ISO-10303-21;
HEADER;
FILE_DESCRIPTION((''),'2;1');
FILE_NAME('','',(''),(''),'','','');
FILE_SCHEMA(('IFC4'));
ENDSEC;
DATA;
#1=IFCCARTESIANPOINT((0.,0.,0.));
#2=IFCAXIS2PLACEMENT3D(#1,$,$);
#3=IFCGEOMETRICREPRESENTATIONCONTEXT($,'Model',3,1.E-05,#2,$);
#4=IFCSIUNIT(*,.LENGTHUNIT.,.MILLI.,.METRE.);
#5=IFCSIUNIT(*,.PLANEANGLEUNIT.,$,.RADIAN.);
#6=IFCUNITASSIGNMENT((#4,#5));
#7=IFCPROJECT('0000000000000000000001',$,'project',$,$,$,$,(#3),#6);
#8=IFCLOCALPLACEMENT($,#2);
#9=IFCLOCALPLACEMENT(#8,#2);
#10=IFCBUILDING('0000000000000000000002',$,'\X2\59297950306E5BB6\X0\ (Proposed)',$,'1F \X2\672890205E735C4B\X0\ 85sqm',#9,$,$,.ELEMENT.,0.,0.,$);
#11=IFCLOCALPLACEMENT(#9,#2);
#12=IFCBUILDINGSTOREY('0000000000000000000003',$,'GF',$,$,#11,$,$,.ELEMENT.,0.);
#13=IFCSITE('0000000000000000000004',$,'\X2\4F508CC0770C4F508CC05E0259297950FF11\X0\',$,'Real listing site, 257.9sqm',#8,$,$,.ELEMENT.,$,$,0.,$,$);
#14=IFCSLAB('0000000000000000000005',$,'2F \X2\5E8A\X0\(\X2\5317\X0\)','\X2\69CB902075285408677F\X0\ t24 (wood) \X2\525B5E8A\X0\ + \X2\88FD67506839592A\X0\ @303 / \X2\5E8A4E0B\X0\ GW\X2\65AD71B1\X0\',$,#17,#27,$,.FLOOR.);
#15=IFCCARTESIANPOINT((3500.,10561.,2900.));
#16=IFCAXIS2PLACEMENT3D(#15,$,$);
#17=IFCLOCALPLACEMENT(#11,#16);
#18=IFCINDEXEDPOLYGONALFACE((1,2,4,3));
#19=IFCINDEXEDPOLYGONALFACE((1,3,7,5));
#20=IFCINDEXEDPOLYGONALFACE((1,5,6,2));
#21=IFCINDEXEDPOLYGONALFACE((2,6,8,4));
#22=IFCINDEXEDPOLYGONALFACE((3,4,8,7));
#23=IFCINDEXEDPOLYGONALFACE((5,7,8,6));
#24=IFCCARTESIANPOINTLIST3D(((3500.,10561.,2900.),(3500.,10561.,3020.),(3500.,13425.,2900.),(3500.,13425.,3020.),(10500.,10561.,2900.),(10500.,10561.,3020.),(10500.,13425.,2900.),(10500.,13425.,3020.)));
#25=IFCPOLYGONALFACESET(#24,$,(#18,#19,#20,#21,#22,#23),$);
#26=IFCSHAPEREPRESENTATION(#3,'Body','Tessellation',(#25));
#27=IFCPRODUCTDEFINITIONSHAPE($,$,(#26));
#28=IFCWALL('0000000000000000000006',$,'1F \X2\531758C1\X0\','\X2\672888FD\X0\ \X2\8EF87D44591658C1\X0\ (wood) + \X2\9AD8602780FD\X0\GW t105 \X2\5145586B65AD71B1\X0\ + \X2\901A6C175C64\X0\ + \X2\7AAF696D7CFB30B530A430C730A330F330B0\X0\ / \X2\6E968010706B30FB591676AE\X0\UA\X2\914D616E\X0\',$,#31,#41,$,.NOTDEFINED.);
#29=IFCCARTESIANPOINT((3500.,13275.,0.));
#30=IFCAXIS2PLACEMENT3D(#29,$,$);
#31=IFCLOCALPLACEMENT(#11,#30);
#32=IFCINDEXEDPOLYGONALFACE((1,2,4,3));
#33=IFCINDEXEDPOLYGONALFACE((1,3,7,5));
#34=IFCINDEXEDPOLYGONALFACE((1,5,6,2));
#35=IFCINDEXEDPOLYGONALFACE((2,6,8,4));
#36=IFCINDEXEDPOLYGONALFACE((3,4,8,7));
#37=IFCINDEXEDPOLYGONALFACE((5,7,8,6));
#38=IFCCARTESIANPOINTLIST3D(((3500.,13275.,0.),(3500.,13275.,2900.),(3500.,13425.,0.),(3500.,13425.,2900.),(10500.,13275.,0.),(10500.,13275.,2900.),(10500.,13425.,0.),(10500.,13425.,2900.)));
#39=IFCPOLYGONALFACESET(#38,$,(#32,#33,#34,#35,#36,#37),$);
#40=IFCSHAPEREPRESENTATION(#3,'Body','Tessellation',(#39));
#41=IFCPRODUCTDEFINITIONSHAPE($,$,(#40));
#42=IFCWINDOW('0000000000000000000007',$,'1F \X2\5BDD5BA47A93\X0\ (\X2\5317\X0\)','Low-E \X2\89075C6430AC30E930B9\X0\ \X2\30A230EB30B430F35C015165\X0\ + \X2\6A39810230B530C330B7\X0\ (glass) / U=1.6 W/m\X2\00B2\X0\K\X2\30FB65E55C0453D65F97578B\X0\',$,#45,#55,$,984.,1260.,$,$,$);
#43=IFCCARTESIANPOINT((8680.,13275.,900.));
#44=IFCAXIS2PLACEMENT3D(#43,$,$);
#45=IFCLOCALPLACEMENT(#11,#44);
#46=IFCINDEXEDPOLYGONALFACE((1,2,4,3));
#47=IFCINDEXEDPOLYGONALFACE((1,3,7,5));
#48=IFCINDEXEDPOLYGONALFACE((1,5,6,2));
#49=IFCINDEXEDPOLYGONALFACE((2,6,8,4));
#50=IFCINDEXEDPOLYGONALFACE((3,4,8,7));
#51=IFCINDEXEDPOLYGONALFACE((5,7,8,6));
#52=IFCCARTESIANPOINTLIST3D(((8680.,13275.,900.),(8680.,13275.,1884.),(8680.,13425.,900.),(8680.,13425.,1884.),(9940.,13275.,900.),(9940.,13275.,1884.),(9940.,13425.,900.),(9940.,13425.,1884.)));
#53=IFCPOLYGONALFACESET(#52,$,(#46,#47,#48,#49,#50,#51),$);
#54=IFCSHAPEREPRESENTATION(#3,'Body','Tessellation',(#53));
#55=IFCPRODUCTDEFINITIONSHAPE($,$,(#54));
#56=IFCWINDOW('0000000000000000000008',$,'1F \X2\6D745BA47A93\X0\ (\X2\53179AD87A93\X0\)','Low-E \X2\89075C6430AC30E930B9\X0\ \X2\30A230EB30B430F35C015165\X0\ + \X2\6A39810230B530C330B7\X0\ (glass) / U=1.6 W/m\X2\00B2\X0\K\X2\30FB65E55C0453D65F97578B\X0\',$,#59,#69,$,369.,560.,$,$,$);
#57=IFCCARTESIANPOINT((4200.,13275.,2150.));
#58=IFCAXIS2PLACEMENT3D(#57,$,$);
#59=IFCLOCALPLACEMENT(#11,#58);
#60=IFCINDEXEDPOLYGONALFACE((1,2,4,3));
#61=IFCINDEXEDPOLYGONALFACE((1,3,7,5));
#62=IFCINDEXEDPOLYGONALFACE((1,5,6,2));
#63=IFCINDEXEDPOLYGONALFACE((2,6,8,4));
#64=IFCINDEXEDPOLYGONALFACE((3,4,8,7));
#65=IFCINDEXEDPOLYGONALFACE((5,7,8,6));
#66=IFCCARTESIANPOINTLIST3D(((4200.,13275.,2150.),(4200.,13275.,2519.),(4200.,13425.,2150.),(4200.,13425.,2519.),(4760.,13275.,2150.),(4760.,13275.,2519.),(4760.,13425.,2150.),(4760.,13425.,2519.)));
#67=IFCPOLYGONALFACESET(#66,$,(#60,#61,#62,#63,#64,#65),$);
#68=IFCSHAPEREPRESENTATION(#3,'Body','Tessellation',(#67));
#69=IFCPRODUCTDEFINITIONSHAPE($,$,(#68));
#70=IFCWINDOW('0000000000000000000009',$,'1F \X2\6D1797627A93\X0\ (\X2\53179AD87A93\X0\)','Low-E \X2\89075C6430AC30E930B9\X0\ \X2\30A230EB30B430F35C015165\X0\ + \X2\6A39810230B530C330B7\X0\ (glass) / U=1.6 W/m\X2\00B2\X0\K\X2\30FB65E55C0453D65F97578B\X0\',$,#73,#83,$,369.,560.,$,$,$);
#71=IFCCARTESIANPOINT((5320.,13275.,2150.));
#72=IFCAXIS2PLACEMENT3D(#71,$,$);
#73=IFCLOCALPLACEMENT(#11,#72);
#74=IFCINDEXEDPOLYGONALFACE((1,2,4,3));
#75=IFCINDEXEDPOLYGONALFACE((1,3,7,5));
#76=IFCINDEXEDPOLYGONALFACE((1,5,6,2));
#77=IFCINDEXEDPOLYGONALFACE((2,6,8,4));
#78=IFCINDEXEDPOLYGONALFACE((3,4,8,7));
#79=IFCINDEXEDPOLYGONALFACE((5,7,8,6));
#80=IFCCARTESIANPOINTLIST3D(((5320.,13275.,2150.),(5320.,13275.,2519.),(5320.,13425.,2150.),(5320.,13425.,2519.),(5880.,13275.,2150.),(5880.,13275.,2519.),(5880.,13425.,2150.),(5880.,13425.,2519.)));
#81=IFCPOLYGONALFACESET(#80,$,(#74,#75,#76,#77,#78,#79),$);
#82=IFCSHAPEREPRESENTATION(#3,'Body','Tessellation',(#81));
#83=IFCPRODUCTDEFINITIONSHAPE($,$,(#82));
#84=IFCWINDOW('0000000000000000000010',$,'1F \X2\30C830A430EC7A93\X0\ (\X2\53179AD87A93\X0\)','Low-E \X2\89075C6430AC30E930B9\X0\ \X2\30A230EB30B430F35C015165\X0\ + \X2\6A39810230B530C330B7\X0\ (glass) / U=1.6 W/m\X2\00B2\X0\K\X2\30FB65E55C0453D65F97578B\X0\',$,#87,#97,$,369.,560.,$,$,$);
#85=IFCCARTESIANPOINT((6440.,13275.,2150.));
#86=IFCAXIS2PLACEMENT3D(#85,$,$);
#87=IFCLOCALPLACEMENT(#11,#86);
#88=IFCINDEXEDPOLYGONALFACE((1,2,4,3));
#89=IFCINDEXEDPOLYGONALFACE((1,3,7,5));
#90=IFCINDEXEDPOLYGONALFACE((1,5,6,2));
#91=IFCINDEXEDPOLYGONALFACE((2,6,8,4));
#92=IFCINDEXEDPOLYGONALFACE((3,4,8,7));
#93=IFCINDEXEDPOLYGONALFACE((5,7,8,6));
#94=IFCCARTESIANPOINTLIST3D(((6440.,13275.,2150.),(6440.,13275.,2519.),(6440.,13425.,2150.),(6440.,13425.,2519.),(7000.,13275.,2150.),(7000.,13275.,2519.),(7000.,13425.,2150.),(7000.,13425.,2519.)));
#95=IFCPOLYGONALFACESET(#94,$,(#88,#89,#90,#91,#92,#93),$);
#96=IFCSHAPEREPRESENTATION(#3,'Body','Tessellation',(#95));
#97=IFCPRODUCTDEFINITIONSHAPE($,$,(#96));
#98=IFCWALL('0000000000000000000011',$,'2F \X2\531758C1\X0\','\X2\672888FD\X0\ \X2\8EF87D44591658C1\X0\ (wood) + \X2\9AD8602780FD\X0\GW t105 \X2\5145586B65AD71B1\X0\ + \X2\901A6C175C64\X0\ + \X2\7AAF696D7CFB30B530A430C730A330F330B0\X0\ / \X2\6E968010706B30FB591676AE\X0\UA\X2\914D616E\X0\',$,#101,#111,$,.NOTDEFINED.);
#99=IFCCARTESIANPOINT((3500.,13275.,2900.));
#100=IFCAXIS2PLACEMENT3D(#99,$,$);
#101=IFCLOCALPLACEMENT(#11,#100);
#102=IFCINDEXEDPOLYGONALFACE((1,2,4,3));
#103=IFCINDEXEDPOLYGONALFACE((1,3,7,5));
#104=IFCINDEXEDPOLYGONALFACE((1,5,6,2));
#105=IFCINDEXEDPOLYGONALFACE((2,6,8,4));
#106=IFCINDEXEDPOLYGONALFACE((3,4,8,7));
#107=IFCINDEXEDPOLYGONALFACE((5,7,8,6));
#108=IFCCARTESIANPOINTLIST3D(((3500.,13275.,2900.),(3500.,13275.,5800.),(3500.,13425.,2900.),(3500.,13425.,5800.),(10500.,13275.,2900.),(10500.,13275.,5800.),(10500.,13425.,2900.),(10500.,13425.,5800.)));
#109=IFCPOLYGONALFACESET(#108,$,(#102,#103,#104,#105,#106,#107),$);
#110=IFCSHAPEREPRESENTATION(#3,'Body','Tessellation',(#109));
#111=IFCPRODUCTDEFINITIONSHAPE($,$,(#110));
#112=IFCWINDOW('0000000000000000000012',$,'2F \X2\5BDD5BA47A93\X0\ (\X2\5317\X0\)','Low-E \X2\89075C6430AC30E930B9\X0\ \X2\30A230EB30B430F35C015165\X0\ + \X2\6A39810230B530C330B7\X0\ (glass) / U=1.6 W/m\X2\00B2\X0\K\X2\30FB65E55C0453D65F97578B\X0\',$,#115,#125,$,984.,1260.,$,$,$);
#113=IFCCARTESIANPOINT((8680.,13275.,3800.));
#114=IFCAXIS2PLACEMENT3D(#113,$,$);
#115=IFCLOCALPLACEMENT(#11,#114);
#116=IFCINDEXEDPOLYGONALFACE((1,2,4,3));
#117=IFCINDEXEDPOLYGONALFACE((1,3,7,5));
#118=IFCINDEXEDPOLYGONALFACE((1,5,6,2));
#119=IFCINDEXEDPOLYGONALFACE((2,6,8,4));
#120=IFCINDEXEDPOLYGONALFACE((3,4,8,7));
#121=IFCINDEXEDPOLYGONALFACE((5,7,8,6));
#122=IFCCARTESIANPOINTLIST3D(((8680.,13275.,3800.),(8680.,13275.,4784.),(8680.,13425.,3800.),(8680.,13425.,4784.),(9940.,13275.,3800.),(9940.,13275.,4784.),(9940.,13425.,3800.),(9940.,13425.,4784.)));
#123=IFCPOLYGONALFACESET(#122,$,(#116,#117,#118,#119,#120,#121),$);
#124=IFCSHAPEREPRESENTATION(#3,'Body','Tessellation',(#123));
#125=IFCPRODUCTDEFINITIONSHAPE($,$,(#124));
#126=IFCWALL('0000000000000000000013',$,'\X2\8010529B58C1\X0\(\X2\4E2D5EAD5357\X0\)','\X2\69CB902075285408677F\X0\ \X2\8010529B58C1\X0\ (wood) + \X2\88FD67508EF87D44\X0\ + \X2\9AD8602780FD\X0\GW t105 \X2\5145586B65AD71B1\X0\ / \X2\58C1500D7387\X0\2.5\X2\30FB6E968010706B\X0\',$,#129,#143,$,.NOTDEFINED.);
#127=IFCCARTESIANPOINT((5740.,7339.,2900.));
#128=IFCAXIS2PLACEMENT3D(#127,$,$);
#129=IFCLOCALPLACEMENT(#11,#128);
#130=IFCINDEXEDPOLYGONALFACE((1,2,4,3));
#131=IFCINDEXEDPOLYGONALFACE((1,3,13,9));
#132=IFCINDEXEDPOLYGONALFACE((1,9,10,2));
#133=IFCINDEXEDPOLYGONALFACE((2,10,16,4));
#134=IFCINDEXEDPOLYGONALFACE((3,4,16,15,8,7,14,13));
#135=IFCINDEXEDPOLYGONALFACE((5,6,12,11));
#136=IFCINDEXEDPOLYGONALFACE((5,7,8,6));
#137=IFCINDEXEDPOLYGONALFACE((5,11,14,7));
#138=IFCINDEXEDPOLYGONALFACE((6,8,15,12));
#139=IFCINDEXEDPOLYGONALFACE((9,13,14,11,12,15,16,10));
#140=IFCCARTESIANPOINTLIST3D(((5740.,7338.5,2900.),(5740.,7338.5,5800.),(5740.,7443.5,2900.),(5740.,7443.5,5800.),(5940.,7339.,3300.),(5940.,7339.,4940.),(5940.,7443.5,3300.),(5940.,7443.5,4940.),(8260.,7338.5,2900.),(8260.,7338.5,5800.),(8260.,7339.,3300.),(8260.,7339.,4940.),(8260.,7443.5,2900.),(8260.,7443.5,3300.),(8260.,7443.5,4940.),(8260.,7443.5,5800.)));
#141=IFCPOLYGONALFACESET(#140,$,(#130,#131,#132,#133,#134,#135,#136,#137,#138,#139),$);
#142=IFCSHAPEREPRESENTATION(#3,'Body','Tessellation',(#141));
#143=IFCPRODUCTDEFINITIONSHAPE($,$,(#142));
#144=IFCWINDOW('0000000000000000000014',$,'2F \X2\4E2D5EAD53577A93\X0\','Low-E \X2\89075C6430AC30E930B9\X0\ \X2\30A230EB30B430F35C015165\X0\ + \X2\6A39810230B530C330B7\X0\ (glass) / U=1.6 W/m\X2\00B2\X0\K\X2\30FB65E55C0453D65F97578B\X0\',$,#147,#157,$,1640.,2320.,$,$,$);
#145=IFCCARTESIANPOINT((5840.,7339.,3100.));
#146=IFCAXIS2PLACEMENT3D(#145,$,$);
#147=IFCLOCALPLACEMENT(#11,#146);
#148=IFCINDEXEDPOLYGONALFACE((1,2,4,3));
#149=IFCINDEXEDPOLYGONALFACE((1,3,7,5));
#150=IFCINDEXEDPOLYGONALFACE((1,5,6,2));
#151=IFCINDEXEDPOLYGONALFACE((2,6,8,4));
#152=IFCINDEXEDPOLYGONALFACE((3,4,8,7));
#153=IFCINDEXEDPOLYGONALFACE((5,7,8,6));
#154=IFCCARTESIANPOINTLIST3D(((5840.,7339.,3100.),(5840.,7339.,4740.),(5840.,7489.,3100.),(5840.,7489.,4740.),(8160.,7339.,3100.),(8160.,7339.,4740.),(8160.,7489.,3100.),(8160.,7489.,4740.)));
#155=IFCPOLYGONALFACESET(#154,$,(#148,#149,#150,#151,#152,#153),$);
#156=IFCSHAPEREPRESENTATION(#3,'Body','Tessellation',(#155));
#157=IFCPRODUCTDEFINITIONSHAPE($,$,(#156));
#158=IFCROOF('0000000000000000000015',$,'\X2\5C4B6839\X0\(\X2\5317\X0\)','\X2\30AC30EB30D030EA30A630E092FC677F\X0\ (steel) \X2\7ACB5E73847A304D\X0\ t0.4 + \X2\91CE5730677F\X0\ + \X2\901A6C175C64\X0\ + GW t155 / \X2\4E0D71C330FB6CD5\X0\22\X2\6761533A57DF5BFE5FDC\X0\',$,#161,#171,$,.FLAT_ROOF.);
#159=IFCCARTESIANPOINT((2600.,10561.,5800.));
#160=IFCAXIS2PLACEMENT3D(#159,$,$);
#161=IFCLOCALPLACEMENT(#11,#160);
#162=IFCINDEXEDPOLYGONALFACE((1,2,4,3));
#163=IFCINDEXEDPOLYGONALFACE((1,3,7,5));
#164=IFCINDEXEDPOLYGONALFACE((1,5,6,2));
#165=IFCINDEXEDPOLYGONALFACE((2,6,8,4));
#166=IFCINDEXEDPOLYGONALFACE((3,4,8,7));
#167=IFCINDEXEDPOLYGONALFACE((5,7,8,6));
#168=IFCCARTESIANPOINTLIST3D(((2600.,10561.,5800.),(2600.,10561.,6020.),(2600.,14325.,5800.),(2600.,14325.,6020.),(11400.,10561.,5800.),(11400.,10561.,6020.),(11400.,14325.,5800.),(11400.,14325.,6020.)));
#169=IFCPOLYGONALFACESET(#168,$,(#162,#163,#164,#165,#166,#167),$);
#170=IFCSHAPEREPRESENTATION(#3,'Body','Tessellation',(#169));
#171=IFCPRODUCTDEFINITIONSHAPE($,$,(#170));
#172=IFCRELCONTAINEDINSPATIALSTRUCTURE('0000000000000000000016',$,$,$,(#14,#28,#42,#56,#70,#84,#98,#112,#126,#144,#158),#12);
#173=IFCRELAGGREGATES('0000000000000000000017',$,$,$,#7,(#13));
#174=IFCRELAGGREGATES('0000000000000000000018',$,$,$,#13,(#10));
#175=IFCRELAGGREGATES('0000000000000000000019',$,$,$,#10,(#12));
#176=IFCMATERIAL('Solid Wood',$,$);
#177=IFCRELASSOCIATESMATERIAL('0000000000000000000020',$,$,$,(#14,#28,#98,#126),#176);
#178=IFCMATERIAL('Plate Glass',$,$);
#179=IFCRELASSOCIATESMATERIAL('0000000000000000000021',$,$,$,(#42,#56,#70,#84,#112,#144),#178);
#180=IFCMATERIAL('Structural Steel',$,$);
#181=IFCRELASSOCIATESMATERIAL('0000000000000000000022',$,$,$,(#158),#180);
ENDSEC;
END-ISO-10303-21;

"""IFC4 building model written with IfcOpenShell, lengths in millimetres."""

from ifc_helpers import new_model, si_unit, frame, frame_2d, origin, place, context, project, spatial, rectangle, extrude, material, element, fill, save


model = new_model("IFC4")

# Units and contexts
model_context = context("Model", 3, precision=1e-05, world=origin())
ifc_project = project(units=[si_unit("LENGTHUNIT", "METRE", prefix="MILLI"), si_unit("PLANEANGLEUNIT", "RADIAN")], contexts=[model_context])

# Site, building, storey
site_placement = place(None, origin())
site = spatial("IfcSite", under=ifc_project, at=site_placement, Name="佐賀県佐賀市天祐１", ObjectType="Real listing site, 257.9sqm", CompositionType="ELEMENT", RefElevation=0.0)
building_placement = place(site_placement, origin())
building = spatial("IfcBuilding", under=site, at=building_placement, Name="天祐の家 (Proposed)", ObjectType="1F 木造平屋 85sqm", CompositionType="ELEMENT", ElevationOfRefHeight=0.0, ElevationOfTerrain=0.0)
storey_placement = place(building_placement, origin())
storey = spatial("IfcBuildingStorey", under=building, at=storey_placement, Name="GF", CompositionType="ELEMENT", Elevation=0.0)

# Slab
ifc_material_1 = material(Name="Solid Wood")
slab_1_placement = place(storey_placement, frame((3500.0, 10561.0, 2900.0)))
element("IfcSlab", 1, at=slab_1_placement, inside=storey, material=ifc_material_1, Name="2F 床(北)", Description="構造用合板 t24 (wood) 剛床 + 製材根太 @303 / 床下 GW断熱", PredefinedType="FLOOR", context=model_context, shape_type="SweptSolid", body=[
    extrude(rectangle(XDim=7000.0, YDim=2864.0, at=frame_2d((3500.0, 1432.0))), frame((3500.0, 10561.0, 2900.0)), (0.0, 0.0, 1.0), 120.0),
])

# Wall, openings, windows
wall_1_placement = place(storey_placement, frame((3500.0, 13275.0, 0.0)))
wall_1 = element("IfcWall", 2, at=wall_1_placement, inside=storey, material=ifc_material_1, Name="1F 北壁", Description="木製 軸組外壁 (wood) + 高性能GW t105 充填断熱 + 通気層 + 窯業系サイディング / 準耐火・外皮UA配慮", PredefinedType="NOTDEFINED", context=model_context, shape_type="SweptSolid", body=[
    extrude(rectangle(XDim=7000.0, YDim=150.0, at=frame_2d((3500.0, 75.0))), frame((3500.0, 13275.0, 0.0)), (0.0, 0.0, 1.0), 2900.0),
])
opening_1_placement = place(storey_placement, frame((8680.0, 13275.0, 900.0)))
opening_1 = element("IfcOpeningElement", 3, at=opening_1_placement, cuts=wall_1, PredefinedType="NOTDEFINED", context=model_context, shape_type="SweptSolid", body=[
    extrude(rectangle(XDim=1260.0, YDim=150.0, at=frame_2d((630.0, 75.0))), frame((8680.0, 13275.0, 900.0)), (0.0, 0.0, 1.0), 984.0),
])
opening_2_placement = place(storey_placement, frame((4200.0, 13275.0, 2150.0)))
opening_2 = element("IfcOpeningElement", 4, at=opening_2_placement, cuts=wall_1, PredefinedType="NOTDEFINED", context=model_context, shape_type="SweptSolid", body=[
    extrude(rectangle(XDim=560.0, YDim=150.0, at=frame_2d((280.0, 75.0))), frame((4200.0, 13275.0, 2150.0)), (0.0, 0.0, 1.0), 369.0),
])
opening_3_placement = place(storey_placement, frame((5320.0, 13275.0, 2150.0)))
opening_3 = element("IfcOpeningElement", 5, at=opening_3_placement, cuts=wall_1, PredefinedType="NOTDEFINED", context=model_context, shape_type="SweptSolid", body=[
    extrude(rectangle(XDim=560.0, YDim=150.0, at=frame_2d((280.0, 75.0))), frame((5320.0, 13275.0, 2150.0)), (0.0, 0.0, 1.0), 369.0),
])
opening_4_placement = place(storey_placement, frame((6440.0, 13275.0, 2150.0)))
opening_4 = element("IfcOpeningElement", 6, at=opening_4_placement, cuts=wall_1, PredefinedType="NOTDEFINED", context=model_context, shape_type="SweptSolid", body=[
    extrude(rectangle(XDim=560.0, YDim=150.0, at=frame_2d((280.0, 75.0))), frame((6440.0, 13275.0, 2150.0)), (0.0, 0.0, 1.0), 369.0),
])
ifc_material_2 = material(Name="Plate Glass")
window_1_placement = place(storey_placement, frame((8680.0, 13275.0, 900.0)))
window_1 = element("IfcWindow", 7, at=window_1_placement, inside=storey, material=ifc_material_2, Name="1F 寝室窓 (北)", Description="Low-E 複層ガラス アルゴン封入 + 樹脂サッシ (glass) / U=1.6 W/m²K・日射取得型", OverallHeight=984.0, OverallWidth=1260.0, context=model_context, shape_type="SweptSolid", body=[
    extrude(rectangle(XDim=1260.0, YDim=150.0, at=frame_2d((630.0, 75.0))), frame((8680.0, 13275.0, 900.0)), (0.0, 0.0, 1.0), 984.0),
])
fill(opening_1, window_1)
window_2_placement = place(storey_placement, frame((4200.0, 13275.0, 2150.0)))
window_2 = element("IfcWindow", 8, at=window_2_placement, inside=storey, material=ifc_material_2, Name="1F 浴室窓 (北高窓)", Description="Low-E 複層ガラス アルゴン封入 + 樹脂サッシ (glass) / U=1.6 W/m²K・日射取得型", OverallHeight=369.0, OverallWidth=560.0, context=model_context, shape_type="SweptSolid", body=[
    extrude(rectangle(XDim=560.0, YDim=150.0, at=frame_2d((280.0, 75.0))), frame((4200.0, 13275.0, 2150.0)), (0.0, 0.0, 1.0), 369.0),
])
fill(opening_2, window_2)
window_3_placement = place(storey_placement, frame((5320.0, 13275.0, 2150.0)))
window_3 = element("IfcWindow", 9, at=window_3_placement, inside=storey, material=ifc_material_2, Name="1F 洗面窓 (北高窓)", Description="Low-E 複層ガラス アルゴン封入 + 樹脂サッシ (glass) / U=1.6 W/m²K・日射取得型", OverallHeight=369.0, OverallWidth=560.0, context=model_context, shape_type="SweptSolid", body=[
    extrude(rectangle(XDim=560.0, YDim=150.0, at=frame_2d((280.0, 75.0))), frame((5320.0, 13275.0, 2150.0)), (0.0, 0.0, 1.0), 369.0),
])
fill(opening_3, window_3)
window_4_placement = place(storey_placement, frame((6440.0, 13275.0, 2150.0)))
window_4 = element("IfcWindow", 10, at=window_4_placement, inside=storey, material=ifc_material_2, Name="1F トイレ窓 (北高窓)", Description="Low-E 複層ガラス アルゴン封入 + 樹脂サッシ (glass) / U=1.6 W/m²K・日射取得型", OverallHeight=369.0, OverallWidth=560.0, context=model_context, shape_type="SweptSolid", body=[
    extrude(rectangle(XDim=560.0, YDim=150.0, at=frame_2d((280.0, 75.0))), frame((6440.0, 13275.0, 2150.0)), (0.0, 0.0, 1.0), 369.0),
])
fill(opening_4, window_4)

# Walls, openings, windows
wall_2_placement = place(storey_placement, frame((3500.0, 13275.0, 2900.0)))
wall_2 = element("IfcWall", 11, at=wall_2_placement, inside=storey, material=ifc_material_1, Name="2F 北壁", Description="木製 軸組外壁 (wood) + 高性能GW t105 充填断熱 + 通気層 + 窯業系サイディング / 準耐火・外皮UA配慮", PredefinedType="NOTDEFINED", context=model_context, shape_type="SweptSolid", body=[
    extrude(rectangle(XDim=7000.0, YDim=150.0, at=frame_2d((3500.0, 75.0))), frame((3500.0, 13275.0, 2900.0)), (0.0, 0.0, 1.0), 2900.0),
])
opening_5_placement = place(storey_placement, frame((8680.0, 13275.0, 3800.0)))
opening_5 = element("IfcOpeningElement", 12, at=opening_5_placement, cuts=wall_2, PredefinedType="NOTDEFINED", context=model_context, shape_type="SweptSolid", body=[
    extrude(rectangle(XDim=1260.0, YDim=150.0, at=frame_2d((630.0, 75.0))), frame((8680.0, 13275.0, 3800.0)), (0.0, 0.0, 1.0), 984.0),
])
window_5_placement = place(storey_placement, frame((8680.0, 13275.0, 3800.0)))
window_5 = element("IfcWindow", 13, at=window_5_placement, inside=storey, material=ifc_material_2, Name="2F 寝室窓 (北)", Description="Low-E 複層ガラス アルゴン封入 + 樹脂サッシ (glass) / U=1.6 W/m²K・日射取得型", OverallHeight=984.0, OverallWidth=1260.0, context=model_context, shape_type="SweptSolid", body=[
    extrude(rectangle(XDim=1260.0, YDim=150.0, at=frame_2d((630.0, 75.0))), frame((8680.0, 13275.0, 3800.0)), (0.0, 0.0, 1.0), 984.0),
])
fill(opening_5, window_5)
wall_3_placement = place(storey_placement, frame((5740.0, 7339.0, 2900.0)))
wall_3 = element("IfcWall", 14, at=wall_3_placement, inside=storey, material=ifc_material_1, Name="耐力壁(中庭南)", Description="構造用合板 耐力壁 (wood) + 製材軸組 + 高性能GW t105 充填断熱 / 壁倍率2.5・準耐火", PredefinedType="NOTDEFINED", context=model_context, shape_type="SweptSolid", body=[
    extrude(rectangle(XDim=2520.0, YDim=105.0, at=frame_2d((1260.0, 52.0))), frame((5740.0, 7339.0, 2900.0)), (0.0, 0.0, 1.0), 2900.0),
])
opening_6_placement = place(storey_placement, frame((5840.0, 7339.0, 3100.0)))
opening_6 = element("IfcOpeningElement", 15, at=opening_6_placement, cuts=wall_3, PredefinedType="NOTDEFINED", context=model_context, shape_type="SweptSolid", body=[
    extrude(rectangle(XDim=2320.0, YDim=150.0, at=frame_2d((1160.0, 75.0))), frame((5840.0, 7339.0, 3100.0)), (0.0, 0.0, 1.0), 1640.0),
])
window_6_placement = place(storey_placement, frame((5840.0, 7339.0, 3100.0)))
window_6 = element("IfcWindow", 16, at=window_6_placement, inside=storey, material=ifc_material_2, Name="2F 中庭南窓", Description="Low-E 複層ガラス アルゴン封入 + 樹脂サッシ (glass) / U=1.6 W/m²K・日射取得型", OverallHeight=1640.0, OverallWidth=2320.0, context=model_context, shape_type="SweptSolid", body=[
    extrude(rectangle(XDim=2320.0, YDim=150.0, at=frame_2d((1160.0, 75.0))), frame((5840.0, 7339.0, 3100.0)), (0.0, 0.0, 1.0), 1640.0),
])
fill(opening_6, window_6)

# Roof
ifc_material_3 = material(Name="Structural Steel")
for number, where, name in (
    (17, (2600.0, 10561.0, 5800.0), "屋根(北)"),
):
    element("IfcRoof", number, at=place(storey_placement, frame(where)), inside=storey, material=ifc_material_3, Name=name, Description="ガルバリウム鋼板 (steel) 立平葺き t0.4 + 野地板 + 通気層 + GW t155 / 不燃・法22条区域対応", PredefinedType="FLAT_ROOF", context=model_context, shape_type="SweptSolid", body=[
        extrude(rectangle(XDim=8800.0, YDim=3764.0, at=frame_2d((4400.0, 1882.0))), frame((2600.0, 10561.0, 5800.0)), (0.0, 0.0, 1.0), 220.0),
    ])

save(model, "model.ifc")
